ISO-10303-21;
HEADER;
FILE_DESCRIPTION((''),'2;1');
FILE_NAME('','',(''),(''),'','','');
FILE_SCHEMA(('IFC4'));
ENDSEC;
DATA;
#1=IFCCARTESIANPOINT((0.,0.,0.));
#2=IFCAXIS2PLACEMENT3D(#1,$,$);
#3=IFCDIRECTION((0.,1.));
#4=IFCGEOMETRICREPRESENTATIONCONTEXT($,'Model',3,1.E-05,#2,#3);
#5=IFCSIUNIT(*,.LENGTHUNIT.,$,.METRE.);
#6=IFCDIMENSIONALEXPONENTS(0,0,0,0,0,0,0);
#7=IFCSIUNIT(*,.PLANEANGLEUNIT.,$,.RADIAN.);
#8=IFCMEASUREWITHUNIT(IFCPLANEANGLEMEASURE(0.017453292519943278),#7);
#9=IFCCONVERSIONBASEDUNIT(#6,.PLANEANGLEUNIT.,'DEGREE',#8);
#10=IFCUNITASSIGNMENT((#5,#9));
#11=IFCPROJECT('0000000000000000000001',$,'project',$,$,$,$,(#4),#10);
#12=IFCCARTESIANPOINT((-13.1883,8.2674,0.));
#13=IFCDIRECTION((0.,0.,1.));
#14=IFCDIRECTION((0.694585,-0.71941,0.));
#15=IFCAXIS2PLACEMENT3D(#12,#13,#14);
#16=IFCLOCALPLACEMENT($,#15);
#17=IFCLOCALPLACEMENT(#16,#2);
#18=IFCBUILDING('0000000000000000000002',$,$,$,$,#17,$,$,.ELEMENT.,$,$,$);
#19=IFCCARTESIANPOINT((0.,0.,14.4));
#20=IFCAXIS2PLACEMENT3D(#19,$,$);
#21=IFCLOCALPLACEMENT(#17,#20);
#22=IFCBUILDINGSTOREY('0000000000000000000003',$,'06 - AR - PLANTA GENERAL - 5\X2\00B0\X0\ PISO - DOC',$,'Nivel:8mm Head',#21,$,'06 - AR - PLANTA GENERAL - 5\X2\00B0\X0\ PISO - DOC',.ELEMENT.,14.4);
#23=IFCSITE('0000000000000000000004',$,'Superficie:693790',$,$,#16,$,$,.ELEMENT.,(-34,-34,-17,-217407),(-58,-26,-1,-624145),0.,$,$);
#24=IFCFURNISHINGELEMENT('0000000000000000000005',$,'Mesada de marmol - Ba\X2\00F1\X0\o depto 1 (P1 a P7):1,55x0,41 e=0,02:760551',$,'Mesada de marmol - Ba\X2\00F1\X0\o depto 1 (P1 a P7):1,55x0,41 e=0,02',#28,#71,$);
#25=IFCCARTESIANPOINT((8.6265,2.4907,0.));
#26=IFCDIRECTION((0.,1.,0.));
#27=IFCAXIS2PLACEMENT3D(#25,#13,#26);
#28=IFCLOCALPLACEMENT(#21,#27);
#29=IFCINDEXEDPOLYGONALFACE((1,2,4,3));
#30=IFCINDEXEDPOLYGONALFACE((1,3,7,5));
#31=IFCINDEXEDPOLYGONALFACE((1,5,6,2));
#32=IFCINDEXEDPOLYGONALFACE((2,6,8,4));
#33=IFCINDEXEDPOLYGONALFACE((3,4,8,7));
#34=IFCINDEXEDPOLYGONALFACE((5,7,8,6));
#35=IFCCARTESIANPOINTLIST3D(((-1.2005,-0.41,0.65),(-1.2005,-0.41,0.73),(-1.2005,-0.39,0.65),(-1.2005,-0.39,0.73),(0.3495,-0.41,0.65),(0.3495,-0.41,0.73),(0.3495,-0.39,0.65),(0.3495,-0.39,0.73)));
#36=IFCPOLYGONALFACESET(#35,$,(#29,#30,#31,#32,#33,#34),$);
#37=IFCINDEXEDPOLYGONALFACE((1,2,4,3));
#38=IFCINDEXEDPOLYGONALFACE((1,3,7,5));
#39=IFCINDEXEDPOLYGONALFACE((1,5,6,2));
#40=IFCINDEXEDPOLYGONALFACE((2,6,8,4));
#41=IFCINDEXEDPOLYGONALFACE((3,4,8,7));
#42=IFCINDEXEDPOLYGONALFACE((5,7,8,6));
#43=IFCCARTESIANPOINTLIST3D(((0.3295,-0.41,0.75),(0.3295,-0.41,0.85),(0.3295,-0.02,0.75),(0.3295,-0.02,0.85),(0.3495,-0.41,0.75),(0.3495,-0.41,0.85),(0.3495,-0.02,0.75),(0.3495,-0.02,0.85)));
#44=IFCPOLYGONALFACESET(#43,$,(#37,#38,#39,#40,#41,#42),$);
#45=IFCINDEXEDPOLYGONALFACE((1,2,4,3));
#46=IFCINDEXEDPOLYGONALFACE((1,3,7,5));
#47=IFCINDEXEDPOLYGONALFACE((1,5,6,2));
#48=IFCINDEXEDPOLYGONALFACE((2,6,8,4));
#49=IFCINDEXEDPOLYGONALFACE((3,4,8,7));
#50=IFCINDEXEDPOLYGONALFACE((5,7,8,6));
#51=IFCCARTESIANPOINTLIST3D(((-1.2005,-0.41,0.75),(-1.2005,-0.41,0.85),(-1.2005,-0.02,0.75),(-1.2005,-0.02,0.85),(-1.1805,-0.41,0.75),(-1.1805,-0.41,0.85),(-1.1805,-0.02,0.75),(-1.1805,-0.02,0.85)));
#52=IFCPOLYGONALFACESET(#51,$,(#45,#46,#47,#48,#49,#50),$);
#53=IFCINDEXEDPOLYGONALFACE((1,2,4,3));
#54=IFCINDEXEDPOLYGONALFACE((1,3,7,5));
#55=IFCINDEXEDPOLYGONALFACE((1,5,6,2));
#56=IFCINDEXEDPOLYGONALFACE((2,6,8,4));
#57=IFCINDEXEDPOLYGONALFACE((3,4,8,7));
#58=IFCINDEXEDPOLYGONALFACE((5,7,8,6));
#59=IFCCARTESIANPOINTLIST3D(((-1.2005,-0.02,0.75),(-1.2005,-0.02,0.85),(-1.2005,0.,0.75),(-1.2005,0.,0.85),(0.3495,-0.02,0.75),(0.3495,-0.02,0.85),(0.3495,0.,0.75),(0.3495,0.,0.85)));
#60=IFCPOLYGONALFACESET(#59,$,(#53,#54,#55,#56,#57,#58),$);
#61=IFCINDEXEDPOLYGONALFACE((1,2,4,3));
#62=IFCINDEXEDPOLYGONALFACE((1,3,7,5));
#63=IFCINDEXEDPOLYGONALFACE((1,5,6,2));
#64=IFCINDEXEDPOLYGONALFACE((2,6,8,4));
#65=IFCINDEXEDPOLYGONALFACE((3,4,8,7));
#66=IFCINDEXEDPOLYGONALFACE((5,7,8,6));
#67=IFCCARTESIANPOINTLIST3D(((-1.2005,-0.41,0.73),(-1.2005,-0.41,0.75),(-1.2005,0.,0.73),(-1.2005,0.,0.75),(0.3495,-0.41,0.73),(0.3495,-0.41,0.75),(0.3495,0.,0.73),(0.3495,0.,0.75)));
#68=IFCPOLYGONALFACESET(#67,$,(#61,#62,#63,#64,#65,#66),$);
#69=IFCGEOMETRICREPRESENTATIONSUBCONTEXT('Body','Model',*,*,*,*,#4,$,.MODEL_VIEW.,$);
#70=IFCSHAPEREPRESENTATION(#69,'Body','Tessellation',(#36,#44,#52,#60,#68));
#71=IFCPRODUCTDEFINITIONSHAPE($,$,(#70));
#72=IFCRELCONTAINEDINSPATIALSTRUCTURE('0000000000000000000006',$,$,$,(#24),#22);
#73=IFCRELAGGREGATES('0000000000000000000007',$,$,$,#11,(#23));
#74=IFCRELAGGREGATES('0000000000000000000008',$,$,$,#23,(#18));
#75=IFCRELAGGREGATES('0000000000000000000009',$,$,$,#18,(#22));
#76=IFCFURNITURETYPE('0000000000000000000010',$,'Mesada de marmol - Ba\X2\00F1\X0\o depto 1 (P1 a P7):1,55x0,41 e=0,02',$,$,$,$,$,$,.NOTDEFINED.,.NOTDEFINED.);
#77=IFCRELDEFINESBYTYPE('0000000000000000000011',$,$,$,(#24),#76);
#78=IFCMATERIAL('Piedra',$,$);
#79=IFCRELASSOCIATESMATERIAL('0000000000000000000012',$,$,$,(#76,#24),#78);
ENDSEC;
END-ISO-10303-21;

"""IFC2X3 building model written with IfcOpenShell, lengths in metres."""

from ifc_helpers import new_model, entity, si_unit, converted_unit, direction, frame, frame_2d, origin, origin_2d_with_axis, place, context, subcontext, project, spatial, rectangle, extrude, source, transform, mapped, material, type_object, type_shapes, element, save


model = new_model("IFC2X3")

# Units and contexts
model_context = context("Model", 3, precision=1e-05, world=origin(), true_north=direction((0.0, 1.0)))
body_context = subcontext(model_context, "Body", "Model", "MODEL_VIEW")
ifc_project = project(units=[si_unit("LENGTHUNIT", "METRE"), converted_unit("PLANEANGLEUNIT", "DEGREE", entity("IfcPlaneAngleMeasure", 0.017453292519943278), si_unit("PLANEANGLEUNIT", "RADIAN"), dimensions=[0, 0, 0, 0, 0, 0, 0])], contexts=[model_context])

# Site, building, storey
site_placement = place(None, frame((-13.1883, 8.2674, 0.0), z_axis=(0.0, 0.0, 1.0), x_axis=(0.694585, -0.71941, 0.0)))
site = spatial("IfcSite", under=ifc_project, at=site_placement, Name="Superficie:693790", CompositionType="ELEMENT", RefLatitude=(-34, -34, -17, -217407), RefLongitude=(-58, -26, -1, -624145), RefElevation=0.0)
building_placement = place(site_placement, origin())
building = spatial("IfcBuilding", under=site, at=building_placement, CompositionType="ELEMENT")
storey_placement = place(building_placement, frame((0.0, 0.0, 14.4)))
storey = spatial("IfcBuildingStorey", under=building, at=storey_placement, Name="06 - AR - PLANTA GENERAL - 5° PISO - DOC", ObjectType="Nivel:8mm Head", LongName="06 - AR - PLANTA GENERAL - 5° PISO - DOC", CompositionType="ELEMENT", Elevation=14.4)

# Furnishing element
ifc_material_1 = material(Name="Piedra")
furniture_type = type_object("IfcFurnitureType", Name="Mesada de marmol - Baño depto 1 (P1 a P7):1,55x0,41 e=0,02", AssemblyPlace="NOTDEFINED", material=ifc_material_1)
shared_shape_1 = source(origin(), body_context, "Body", "SweptSolid", [
    extrude(rectangle(XDim=0.02, YDim=1.55, at=frame_2d((0.0, 0.0), x_axis=(1.0, 0.0))), frame((-0.4255, -0.4, 0.65), z_axis=(0.0, 0.0, 1.0), x_axis=(0.0, 1.0, 0.0)), (0.0, 0.0, 1.0), 0.08),
    extrude(rectangle(XDim=0.39, YDim=0.02, at=origin_2d_with_axis()), frame((0.3395, -0.215, 0.75), z_axis=(0.0, 0.0, 1.0), x_axis=(0.0, 1.0, 0.0)), (0.0, 0.0, 1.0), 0.1),
    extrude(rectangle(XDim=0.02, YDim=0.39, at=origin_2d_with_axis()), frame((-1.1905, -0.215, 0.75), z_axis=(0.0, 0.0, 1.0), x_axis=(-1.0, 0.0, 0.0)), (0.0, 0.0, 1.0), 0.1),
    extrude(rectangle(XDim=0.02, YDim=1.55, at=origin_2d_with_axis()), frame((-0.4255, -0.01, 0.75), z_axis=(0.0, 0.0, 1.0), x_axis=(0.0, -1.0, 0.0)), (0.0, 0.0, 1.0), 0.1),
    extrude(rectangle(XDim=1.55, YDim=0.41, at=origin_2d_with_axis()), frame((-0.4255, -0.205, 0.73), z_axis=(0.0, 0.0, 1.0), x_axis=(-1.0, 0.0, 0.0)), (0.0, 0.0, 1.0), 0.02),
])
type_shapes(furniture_type, [shared_shape_1])
furnishing_placement = place(storey_placement, frame((8.6265, 2.4907, 0.0), z_axis=(0.0, 0.0, 1.0), x_axis=(0.0, 1.0, 0.0)))
element("IfcFurnishingElement", 1, at=furnishing_placement, inside=storey, type_object=furniture_type, material=ifc_material_1, Name="Mesada de marmol - Baño depto 1 (P1 a P7):1,55x0,41 e=0,02:760551", ObjectType="Mesada de marmol - Baño depto 1 (P1 a P7):1,55x0,41 e=0,02", context=body_context, shape_type="MappedRepresentation", body=[
    mapped(shared_shape_1, transform((0.0, 0.0, 0.0), scale=1.0)),
])

save(model, "model.ifc")
